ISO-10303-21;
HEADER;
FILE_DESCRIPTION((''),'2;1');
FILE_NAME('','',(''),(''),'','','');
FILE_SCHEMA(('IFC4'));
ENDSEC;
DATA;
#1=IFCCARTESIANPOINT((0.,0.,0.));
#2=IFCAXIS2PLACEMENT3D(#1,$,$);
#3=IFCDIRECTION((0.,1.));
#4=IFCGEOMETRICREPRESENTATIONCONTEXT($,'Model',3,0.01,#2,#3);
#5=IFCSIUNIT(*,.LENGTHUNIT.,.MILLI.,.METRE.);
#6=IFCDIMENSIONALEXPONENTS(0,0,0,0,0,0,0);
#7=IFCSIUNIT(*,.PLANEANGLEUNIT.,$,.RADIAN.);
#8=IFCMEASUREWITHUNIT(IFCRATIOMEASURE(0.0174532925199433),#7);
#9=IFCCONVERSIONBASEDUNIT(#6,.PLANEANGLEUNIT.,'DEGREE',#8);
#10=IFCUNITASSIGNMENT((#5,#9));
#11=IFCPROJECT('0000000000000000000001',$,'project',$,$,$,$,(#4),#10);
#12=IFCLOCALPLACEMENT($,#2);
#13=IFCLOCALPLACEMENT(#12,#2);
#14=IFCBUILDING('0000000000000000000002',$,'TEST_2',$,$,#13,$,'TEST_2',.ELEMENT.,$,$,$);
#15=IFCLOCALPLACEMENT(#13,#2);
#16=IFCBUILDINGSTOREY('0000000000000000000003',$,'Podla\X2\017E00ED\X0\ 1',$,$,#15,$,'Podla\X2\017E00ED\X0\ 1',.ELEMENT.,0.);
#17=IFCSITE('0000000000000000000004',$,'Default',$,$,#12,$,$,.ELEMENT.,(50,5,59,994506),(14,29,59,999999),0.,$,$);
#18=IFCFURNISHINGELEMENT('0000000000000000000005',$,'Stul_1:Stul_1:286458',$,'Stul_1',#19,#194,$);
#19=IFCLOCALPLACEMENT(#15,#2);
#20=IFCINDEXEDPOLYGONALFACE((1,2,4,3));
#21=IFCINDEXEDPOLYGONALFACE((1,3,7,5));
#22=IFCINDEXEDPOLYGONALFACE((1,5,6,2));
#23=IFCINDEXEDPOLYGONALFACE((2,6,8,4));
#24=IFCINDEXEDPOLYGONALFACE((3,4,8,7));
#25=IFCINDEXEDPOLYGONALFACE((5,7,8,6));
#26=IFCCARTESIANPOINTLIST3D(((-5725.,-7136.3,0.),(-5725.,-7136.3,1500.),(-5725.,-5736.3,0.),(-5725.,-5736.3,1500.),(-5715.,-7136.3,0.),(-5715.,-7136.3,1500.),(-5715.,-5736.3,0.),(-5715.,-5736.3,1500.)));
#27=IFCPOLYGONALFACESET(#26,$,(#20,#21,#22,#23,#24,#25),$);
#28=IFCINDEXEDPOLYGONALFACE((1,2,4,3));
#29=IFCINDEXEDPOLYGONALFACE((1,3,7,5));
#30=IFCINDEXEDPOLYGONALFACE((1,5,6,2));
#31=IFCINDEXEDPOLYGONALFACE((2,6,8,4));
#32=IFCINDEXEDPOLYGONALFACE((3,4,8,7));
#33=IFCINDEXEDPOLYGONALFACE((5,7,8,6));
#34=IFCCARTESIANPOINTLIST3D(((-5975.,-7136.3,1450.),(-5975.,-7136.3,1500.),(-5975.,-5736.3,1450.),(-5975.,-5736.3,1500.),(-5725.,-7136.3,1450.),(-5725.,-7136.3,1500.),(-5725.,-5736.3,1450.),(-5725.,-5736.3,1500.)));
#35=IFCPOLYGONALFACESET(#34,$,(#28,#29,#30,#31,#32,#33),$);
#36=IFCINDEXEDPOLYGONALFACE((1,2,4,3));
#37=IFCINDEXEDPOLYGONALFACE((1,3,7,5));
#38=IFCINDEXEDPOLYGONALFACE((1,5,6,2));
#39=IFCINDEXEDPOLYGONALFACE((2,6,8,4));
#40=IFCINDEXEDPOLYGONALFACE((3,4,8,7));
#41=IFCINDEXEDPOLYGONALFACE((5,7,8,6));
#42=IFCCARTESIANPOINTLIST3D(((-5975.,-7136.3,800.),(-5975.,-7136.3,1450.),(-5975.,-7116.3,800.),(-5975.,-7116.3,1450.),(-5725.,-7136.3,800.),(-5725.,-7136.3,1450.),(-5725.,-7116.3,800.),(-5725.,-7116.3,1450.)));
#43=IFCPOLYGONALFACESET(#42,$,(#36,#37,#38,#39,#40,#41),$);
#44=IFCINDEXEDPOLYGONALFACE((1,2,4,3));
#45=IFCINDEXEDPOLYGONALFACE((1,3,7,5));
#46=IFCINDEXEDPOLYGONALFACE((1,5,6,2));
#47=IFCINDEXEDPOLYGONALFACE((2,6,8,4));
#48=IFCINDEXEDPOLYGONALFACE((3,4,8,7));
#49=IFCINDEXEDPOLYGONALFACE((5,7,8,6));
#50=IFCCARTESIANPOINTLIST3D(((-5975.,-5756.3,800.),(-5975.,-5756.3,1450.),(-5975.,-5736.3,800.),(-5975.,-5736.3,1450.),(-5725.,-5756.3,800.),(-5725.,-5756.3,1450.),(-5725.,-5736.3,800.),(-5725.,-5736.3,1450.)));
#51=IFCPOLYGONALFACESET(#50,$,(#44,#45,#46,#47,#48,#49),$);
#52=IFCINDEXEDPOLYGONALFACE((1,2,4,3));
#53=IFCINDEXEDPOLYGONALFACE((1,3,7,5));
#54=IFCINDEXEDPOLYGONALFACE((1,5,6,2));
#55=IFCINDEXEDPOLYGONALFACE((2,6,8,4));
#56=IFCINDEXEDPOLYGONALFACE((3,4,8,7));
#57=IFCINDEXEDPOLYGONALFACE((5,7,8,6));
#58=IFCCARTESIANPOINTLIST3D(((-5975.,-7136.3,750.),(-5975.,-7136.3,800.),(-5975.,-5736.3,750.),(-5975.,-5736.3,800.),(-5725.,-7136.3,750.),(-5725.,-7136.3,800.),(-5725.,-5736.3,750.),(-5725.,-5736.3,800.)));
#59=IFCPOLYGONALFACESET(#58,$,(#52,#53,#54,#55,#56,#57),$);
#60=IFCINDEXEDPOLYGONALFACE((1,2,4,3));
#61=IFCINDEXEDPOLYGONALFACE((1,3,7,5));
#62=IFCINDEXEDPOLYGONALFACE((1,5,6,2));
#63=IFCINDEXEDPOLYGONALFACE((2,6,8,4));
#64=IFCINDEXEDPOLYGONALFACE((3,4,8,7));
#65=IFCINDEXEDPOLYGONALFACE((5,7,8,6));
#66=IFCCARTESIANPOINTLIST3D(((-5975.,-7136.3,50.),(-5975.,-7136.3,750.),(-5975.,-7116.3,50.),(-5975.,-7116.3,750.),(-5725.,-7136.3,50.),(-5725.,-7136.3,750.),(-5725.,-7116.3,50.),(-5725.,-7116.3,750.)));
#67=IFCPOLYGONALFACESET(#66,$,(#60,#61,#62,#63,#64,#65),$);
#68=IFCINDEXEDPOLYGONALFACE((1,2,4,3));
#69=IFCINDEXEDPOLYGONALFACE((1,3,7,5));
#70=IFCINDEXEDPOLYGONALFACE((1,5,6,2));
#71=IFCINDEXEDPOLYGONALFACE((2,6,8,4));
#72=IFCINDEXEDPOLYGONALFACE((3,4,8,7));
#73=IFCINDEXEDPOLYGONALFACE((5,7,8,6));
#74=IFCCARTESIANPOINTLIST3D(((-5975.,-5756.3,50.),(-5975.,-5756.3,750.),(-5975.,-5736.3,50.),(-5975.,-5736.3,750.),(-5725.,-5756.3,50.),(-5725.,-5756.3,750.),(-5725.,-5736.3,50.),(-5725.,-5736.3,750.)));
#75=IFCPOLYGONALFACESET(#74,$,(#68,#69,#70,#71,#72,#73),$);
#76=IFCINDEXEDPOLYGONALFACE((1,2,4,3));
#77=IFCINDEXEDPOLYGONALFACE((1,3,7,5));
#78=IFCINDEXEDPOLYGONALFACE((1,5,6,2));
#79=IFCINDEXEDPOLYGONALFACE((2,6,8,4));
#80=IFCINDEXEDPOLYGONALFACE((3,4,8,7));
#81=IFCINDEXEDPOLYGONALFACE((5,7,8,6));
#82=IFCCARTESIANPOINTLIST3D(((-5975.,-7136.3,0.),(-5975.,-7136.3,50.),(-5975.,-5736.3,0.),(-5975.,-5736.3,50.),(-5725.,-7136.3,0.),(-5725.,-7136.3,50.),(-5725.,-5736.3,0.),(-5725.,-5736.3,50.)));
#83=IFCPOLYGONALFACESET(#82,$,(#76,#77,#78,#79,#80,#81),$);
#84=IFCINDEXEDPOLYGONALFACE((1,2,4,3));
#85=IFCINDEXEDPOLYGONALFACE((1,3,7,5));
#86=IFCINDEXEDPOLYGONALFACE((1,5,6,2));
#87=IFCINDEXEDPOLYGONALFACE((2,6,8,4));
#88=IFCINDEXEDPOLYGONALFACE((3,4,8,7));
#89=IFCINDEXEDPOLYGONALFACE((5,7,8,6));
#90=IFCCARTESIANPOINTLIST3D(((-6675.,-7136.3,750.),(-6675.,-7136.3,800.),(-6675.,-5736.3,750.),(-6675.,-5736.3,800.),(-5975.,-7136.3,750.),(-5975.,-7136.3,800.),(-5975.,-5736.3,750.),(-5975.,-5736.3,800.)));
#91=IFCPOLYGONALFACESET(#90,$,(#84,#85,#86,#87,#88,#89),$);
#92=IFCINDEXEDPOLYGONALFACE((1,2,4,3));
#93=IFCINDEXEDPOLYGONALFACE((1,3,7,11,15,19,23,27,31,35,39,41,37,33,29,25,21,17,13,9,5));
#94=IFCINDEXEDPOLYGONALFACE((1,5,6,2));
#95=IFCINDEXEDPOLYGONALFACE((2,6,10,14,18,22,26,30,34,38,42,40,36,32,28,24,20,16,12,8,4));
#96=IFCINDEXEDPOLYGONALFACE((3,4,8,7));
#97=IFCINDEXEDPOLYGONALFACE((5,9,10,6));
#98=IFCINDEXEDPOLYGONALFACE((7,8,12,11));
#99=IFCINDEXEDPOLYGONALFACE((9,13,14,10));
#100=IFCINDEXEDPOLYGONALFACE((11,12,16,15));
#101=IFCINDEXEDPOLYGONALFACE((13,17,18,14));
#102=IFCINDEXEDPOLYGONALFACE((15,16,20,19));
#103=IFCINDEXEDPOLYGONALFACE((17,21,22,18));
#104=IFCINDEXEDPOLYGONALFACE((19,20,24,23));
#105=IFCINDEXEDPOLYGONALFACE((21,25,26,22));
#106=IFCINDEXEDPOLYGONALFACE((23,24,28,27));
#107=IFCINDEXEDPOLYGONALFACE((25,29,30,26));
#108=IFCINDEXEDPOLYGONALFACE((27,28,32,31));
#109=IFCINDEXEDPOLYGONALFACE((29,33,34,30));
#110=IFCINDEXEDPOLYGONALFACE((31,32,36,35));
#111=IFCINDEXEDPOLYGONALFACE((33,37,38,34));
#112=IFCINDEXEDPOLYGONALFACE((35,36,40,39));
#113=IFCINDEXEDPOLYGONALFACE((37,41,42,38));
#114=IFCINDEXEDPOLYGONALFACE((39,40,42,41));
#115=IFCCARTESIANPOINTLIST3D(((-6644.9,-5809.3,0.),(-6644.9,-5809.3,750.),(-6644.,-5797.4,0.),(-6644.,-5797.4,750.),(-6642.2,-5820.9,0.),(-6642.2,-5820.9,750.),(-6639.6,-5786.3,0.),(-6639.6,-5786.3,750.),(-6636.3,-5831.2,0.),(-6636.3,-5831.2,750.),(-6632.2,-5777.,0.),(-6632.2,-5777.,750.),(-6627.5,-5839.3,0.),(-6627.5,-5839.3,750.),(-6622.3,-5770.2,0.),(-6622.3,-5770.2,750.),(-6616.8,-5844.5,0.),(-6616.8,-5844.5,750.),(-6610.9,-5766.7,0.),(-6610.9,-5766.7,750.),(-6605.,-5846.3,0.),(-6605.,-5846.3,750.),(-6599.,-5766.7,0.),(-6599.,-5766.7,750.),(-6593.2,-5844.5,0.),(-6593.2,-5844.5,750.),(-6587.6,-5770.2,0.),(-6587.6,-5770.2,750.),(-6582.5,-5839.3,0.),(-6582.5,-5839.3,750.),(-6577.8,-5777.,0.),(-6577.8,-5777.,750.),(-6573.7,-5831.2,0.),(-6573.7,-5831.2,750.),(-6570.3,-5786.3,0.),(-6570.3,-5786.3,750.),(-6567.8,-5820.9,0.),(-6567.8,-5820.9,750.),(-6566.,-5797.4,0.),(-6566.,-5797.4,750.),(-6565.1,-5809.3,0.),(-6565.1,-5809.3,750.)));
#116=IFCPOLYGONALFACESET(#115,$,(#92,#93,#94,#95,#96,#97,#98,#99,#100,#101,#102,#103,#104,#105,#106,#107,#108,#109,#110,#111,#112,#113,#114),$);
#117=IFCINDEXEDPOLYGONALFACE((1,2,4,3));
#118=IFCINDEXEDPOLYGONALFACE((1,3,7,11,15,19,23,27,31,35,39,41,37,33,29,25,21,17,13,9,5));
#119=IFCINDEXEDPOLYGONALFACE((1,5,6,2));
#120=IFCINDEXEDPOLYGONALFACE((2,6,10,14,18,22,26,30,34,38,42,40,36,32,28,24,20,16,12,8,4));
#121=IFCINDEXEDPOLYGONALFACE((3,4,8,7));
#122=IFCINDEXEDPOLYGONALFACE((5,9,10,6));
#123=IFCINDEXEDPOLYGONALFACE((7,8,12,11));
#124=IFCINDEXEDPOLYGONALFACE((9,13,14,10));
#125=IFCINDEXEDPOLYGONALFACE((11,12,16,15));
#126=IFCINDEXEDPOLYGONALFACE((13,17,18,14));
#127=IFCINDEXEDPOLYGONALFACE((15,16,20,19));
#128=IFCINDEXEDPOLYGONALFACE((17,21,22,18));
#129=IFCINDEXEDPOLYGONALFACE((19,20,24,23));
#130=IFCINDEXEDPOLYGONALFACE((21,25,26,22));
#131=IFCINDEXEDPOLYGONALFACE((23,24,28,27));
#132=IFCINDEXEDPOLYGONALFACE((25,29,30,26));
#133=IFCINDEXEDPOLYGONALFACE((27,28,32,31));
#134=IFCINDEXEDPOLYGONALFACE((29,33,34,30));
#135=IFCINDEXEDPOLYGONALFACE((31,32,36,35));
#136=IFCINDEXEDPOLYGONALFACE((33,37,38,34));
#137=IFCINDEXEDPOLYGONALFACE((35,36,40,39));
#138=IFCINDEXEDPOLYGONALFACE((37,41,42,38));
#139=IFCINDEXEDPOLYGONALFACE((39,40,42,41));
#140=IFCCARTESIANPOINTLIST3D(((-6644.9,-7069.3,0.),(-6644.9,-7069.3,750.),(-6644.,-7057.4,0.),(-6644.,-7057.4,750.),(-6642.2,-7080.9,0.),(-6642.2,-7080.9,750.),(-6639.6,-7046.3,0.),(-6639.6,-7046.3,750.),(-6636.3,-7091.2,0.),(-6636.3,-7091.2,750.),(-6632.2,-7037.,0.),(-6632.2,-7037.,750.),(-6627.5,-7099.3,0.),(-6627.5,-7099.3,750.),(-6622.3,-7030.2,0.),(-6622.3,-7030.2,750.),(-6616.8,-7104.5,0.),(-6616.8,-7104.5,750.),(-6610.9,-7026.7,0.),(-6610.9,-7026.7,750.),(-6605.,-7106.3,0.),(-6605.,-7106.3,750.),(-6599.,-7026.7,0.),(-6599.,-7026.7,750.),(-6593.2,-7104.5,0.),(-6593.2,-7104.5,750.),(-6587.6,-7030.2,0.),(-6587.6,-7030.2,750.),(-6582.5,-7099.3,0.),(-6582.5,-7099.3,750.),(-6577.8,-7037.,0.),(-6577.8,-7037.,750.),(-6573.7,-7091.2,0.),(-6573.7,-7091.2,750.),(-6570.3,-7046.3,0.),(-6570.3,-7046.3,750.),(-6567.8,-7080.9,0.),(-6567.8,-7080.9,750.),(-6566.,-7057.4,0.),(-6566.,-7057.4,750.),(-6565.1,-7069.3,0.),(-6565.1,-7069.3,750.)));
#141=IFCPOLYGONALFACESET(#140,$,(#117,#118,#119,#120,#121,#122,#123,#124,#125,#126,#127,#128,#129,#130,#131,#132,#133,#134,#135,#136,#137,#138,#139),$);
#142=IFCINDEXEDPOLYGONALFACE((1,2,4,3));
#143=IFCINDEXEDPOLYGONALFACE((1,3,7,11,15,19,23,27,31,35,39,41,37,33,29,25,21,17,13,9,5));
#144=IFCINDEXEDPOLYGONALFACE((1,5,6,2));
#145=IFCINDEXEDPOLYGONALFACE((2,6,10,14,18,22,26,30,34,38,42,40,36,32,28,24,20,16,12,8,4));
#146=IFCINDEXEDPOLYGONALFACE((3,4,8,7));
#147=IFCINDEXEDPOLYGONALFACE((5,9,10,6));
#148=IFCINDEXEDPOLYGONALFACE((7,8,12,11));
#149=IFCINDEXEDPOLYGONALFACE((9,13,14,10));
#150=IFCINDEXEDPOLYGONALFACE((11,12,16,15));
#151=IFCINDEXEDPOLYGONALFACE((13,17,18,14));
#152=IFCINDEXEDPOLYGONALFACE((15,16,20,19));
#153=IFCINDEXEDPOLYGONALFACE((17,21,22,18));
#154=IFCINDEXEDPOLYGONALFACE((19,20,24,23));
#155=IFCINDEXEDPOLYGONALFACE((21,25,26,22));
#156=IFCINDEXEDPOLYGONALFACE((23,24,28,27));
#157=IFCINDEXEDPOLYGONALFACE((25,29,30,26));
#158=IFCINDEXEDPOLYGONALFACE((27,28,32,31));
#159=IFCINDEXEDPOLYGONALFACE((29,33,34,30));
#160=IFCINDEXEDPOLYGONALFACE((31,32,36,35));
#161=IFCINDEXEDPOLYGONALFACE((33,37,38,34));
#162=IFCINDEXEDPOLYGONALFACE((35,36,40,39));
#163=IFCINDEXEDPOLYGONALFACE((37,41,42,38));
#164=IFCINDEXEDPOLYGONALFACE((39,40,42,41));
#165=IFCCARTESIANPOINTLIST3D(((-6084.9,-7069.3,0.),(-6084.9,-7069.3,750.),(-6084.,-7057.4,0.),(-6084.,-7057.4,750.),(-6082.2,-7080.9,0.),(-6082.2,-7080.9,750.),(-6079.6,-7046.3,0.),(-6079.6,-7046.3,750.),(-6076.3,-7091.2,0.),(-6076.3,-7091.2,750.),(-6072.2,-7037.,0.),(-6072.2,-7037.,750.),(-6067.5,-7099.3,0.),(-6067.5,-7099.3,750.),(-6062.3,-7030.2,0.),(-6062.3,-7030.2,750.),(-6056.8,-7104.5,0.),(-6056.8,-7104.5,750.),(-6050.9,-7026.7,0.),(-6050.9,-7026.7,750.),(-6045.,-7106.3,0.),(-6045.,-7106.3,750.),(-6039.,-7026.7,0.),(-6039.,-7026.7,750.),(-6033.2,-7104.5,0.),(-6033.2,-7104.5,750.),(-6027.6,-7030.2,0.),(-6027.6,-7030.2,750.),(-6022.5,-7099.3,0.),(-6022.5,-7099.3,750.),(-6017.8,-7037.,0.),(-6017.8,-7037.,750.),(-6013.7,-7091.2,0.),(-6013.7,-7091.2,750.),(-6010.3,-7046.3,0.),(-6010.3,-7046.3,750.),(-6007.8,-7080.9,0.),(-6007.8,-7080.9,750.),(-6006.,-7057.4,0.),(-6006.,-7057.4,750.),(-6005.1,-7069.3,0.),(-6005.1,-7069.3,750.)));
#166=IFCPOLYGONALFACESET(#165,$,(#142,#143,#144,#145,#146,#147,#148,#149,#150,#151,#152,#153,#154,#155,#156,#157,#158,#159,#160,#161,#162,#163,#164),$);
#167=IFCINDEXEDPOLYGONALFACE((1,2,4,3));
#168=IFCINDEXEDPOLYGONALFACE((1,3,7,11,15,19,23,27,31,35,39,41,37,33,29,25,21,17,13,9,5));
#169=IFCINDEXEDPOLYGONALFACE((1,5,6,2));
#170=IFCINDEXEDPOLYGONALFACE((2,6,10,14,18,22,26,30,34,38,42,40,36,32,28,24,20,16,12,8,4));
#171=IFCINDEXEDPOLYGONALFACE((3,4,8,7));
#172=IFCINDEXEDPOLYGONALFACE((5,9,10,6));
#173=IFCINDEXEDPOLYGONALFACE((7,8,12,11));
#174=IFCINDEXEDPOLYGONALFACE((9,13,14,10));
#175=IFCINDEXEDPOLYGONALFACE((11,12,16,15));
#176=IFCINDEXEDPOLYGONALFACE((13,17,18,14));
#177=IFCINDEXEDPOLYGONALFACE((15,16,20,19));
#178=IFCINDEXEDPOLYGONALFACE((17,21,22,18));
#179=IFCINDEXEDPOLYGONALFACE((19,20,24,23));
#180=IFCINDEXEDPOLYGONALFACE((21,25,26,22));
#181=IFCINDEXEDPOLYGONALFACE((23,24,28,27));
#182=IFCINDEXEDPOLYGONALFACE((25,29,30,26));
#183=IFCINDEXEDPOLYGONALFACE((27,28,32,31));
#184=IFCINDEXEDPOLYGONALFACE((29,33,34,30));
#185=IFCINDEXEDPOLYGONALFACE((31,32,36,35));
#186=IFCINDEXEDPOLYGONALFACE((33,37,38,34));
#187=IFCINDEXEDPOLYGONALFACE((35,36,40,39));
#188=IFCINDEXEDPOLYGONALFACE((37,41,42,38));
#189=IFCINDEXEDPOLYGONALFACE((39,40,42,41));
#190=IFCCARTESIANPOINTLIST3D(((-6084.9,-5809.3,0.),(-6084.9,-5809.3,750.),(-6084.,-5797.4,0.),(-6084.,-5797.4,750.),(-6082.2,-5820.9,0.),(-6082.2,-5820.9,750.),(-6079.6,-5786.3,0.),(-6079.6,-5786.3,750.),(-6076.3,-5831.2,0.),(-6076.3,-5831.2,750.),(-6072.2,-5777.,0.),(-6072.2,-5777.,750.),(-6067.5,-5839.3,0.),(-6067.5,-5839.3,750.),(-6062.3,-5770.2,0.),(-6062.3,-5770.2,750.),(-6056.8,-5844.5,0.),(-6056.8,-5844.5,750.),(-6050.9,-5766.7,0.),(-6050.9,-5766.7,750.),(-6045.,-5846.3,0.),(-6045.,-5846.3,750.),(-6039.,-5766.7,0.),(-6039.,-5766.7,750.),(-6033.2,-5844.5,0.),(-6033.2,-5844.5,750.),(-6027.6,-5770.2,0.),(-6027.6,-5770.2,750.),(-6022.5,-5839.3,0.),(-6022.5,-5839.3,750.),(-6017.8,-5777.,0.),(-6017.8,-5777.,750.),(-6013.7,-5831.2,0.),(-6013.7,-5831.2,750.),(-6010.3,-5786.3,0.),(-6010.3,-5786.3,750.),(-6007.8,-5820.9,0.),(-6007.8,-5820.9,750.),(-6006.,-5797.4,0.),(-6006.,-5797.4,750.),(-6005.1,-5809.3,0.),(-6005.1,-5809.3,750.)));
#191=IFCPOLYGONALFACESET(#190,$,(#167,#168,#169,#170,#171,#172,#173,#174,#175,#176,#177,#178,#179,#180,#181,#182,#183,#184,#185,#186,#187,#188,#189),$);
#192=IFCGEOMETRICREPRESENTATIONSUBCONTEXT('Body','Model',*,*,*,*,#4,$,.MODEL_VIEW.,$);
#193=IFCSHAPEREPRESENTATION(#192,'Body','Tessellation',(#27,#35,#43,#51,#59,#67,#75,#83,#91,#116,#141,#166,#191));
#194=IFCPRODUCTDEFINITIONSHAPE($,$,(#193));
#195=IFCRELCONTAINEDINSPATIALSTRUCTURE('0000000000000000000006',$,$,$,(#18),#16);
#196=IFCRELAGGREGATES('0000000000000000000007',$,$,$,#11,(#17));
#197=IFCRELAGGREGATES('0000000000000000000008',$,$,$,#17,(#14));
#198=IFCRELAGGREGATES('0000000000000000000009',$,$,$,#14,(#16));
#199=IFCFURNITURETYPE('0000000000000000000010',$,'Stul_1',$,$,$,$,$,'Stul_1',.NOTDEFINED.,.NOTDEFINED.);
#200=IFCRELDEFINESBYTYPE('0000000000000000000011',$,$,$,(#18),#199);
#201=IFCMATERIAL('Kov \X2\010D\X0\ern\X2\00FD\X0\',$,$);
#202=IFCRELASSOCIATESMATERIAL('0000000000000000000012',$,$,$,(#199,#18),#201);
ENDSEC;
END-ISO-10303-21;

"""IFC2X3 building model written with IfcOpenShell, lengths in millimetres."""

from ifc_helpers import new_model, entity, si_unit, converted_unit, direction, frame, frame_2d, origin, origin_2d_with_axis, place, context, subcontext, project, spatial, rectangle, circle, extrude, source, transform, mapped, material, type_object, type_shapes, element, save


model = new_model("IFC2X3")

# Units and contexts
model_context = context("Model", 3, precision=0.01, world=origin(), true_north=direction((0.0, 1.0)))
body_context = subcontext(model_context, "Body", "Model", "MODEL_VIEW")
ifc_project = project(units=[si_unit("LENGTHUNIT", "METRE", prefix="MILLI"), converted_unit("PLANEANGLEUNIT", "DEGREE", entity("IfcRatioMeasure", 0.0174532925199433), si_unit("PLANEANGLEUNIT", "RADIAN"), dimensions=[0, 0, 0, 0, 0, 0, 0])], contexts=[model_context])

# Site, building, storey
site_placement = place(None, origin())
site = spatial("IfcSite", under=ifc_project, at=site_placement, Name="Default", CompositionType="ELEMENT", RefLatitude=(50, 5, 59, 994506), RefLongitude=(14, 29, 59, 999999), RefElevation=0.0)
building_placement = place(site_placement, origin())
building = spatial("IfcBuilding", under=site, at=building_placement, Name="TEST_2", LongName="TEST_2", CompositionType="ELEMENT")
storey_placement = place(building_placement, origin())
storey = spatial("IfcBuildingStorey", under=building, at=storey_placement, Name="Podlaží 1", LongName="Podlaží 1", CompositionType="ELEMENT", Elevation=0.0)

# Furnishing element
ifc_material = material(Name="Kov černý")
furniture_type = type_object("IfcFurnitureType", Name="Stul_1", ElementType="Stul_1", material=ifc_material)
shared_shape = source(origin(), body_context, "Body", "SweptSolid", [
    extrude(rectangle(XDim=1400.0, YDim=10.0, at=origin_2d_with_axis()), frame((0.0, 605.0, 0.0), z_axis=(0.0, 0.0, 1.0), x_axis=(-1.0, 0.0, 0.0)), (0.0, 0.0, 1.0), 1500.0),
    extrude(rectangle(XDim=1400.0, YDim=250.0, at=frame_2d((0.0, 0.0), x_axis=(1.0, 0.0))), frame((0.0, 475.0, 1450.0), z_axis=(0.0, 0.0, 1.0), x_axis=(-1.0, 0.0, 0.0)), (0.0, 0.0, 1.0), 50.0),
    extrude(rectangle(XDim=20.0, YDim=250.0, at=origin_2d_with_axis()), frame((690.0, 475.0, 800.0), z_axis=(0.0, 0.0, 1.0), x_axis=(-1.0, 0.0, 0.0)), (0.0, 0.0, 1.0), 650.0),
    extrude(rectangle(XDim=20.0, YDim=250.0, at=frame_2d((0.0, 0.0), x_axis=(1.0, 0.0))), frame((-690.0, 475.0, 800.0), z_axis=(0.0, 0.0, 1.0), x_axis=(-1.0, 0.0, 0.0)), (0.0, 0.0, 1.0), 650.0),
    extrude(rectangle(XDim=1400.0, YDim=250.0, at=origin_2d_with_axis()), frame((0.0, 475.0, 750.0), z_axis=(0.0, 0.0, 1.0), x_axis=(-1.0, 0.0, 0.0)), (0.0, 0.0, 1.0), 50.0),
    extrude(rectangle(XDim=20.0, YDim=250.0, at=origin_2d_with_axis()), frame((690.0, 475.0, 50.0), z_axis=(0.0, 0.0, 1.0), x_axis=(-1.0, 0.0, 0.0)), (0.0, 0.0, 1.0), 700.0),
    extrude(rectangle(XDim=20.0, YDim=250.0, at=frame_2d((0.0, 0.0), x_axis=(1.0, 0.0))), frame((-690.0, 475.0, 50.0), z_axis=(0.0, 0.0, 1.0), x_axis=(-1.0, 0.0, 0.0)), (0.0, 0.0, 1.0), 700.0),
    extrude(rectangle(XDim=1400.0, YDim=250.0, at=origin_2d_with_axis()), frame((0.0, 475.0, 0.0), z_axis=(0.0, 0.0, 1.0), x_axis=(-1.0, 0.0, 0.0)), (0.0, 0.0, 1.0), 50.0),
    extrude(rectangle(XDim=1400.0, YDim=700.0, at=origin_2d_with_axis()), frame((0.0, 0.0, 750.0), z_axis=(0.0, 0.0, 1.0), x_axis=(-1.0, 0.0, 0.0)), (0.0, 0.0, 1.0), 50.0),
    extrude(circle(Radius=40.0, at=frame_2d((0.0, 0.0), x_axis=(1.0, 0.0))), frame((-630.0, -280.0, 0.0)), (0.0, 0.0, 1.0), 750.0),
    extrude(circle(Radius=40.0, at=frame_2d((0.0, 0.0), x_axis=(1.0, 0.0))), frame((630.0, -280.0, 0.0)), (0.0, 0.0, 1.0), 750.0),
    extrude(circle(Radius=40.0, at=frame_2d((0.0, 0.0), x_axis=(1.0, 0.0))), frame((630.0, 280.0, 0.0)), (0.0, 0.0, 1.0), 750.0),
    extrude(circle(Radius=40.0, at=frame_2d((0.0, 0.0), x_axis=(1.0, 0.0))), frame((-630.0, 280.0, 0.0)), (0.0, 0.0, 1.0), 750.0),
])
type_shapes(furniture_type, [shared_shape])
for number, where, z_axis, x_axis, name in (
    (1, (-6325.0, -6436.3, 0.0), (0.0, 0.0, 1.0), (0.0, -1.0, 0.0), "Stul_1:Stul_1:286458"),
):
    element("IfcFurnishingElement", number, at=place(storey_placement, frame(where, z_axis=z_axis, x_axis=x_axis)), inside=storey, type_object=furniture_type, material=ifc_material, Name=name, ObjectType="Stul_1", context=body_context, shape_type="MappedRepresentation", body=[
        mapped(shared_shape, transform((0.0, 0.0, 0.0), scale=1.0)),
    ])

save(model, "model.ifc")
